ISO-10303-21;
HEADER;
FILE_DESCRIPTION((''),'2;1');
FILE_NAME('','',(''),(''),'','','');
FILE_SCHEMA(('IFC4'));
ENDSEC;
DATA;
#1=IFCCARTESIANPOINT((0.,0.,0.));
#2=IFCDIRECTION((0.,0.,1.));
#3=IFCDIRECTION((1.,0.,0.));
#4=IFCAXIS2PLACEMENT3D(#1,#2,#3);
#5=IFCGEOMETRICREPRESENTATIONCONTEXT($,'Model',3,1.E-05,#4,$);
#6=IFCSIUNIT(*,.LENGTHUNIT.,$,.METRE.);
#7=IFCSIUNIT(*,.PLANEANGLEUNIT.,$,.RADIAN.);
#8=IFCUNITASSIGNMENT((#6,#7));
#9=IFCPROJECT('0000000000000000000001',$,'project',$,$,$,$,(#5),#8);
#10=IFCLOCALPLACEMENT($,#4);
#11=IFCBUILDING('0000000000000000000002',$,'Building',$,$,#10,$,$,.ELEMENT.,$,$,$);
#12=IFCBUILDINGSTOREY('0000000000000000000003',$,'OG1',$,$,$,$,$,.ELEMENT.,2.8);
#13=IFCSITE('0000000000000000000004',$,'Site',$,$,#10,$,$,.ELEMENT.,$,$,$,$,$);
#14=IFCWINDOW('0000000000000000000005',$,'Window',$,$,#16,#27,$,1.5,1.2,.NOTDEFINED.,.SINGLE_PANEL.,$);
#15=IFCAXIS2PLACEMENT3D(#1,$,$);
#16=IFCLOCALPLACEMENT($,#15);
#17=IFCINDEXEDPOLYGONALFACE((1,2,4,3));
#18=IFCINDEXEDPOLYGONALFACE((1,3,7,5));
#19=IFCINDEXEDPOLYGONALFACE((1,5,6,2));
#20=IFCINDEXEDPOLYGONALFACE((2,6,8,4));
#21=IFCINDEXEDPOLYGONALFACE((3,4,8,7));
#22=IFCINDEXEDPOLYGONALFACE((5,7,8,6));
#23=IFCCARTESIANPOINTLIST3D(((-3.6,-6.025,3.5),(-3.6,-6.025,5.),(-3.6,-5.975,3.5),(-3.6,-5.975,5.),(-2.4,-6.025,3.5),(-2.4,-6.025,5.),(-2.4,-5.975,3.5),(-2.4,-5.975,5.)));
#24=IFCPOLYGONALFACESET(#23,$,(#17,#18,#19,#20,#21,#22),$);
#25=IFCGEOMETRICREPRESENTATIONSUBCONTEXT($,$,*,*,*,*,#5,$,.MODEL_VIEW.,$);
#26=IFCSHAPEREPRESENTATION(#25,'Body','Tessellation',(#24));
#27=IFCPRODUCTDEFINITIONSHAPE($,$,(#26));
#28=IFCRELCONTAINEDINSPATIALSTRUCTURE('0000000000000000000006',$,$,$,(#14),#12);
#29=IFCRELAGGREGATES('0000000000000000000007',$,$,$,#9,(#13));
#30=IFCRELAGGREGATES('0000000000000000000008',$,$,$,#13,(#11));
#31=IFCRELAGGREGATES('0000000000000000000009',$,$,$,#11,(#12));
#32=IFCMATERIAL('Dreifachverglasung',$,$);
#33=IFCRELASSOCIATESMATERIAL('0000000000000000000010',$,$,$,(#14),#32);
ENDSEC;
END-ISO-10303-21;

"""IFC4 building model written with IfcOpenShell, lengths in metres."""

from ifc_helpers import new_model, si_unit, frame, origin, origin_with_axes, origin_2d, place, context, subcontext, project, spatial, rectangle, extrude, material, element, save


model = new_model("IFC4")

# Units and contexts
model_context = context("Model", 3, precision=1e-05, world=origin_with_axes())
sub_context = subcontext(model_context, None, None, "MODEL_VIEW")
ifc_project = project(units=[si_unit("LENGTHUNIT", "METRE"), si_unit("PLANEANGLEUNIT", "RADIAN")], contexts=[model_context])

# Site, building, storey
placement_1 = place(None, origin_with_axes())
site = spatial("IfcSite", under=ifc_project, at=placement_1, Name="Site", CompositionType="ELEMENT")
building = spatial("IfcBuilding", under=site, at=placement_1, Name="Building", CompositionType="ELEMENT")
storey = spatial("IfcBuildingStorey", under=building, Name="OG1", CompositionType="ELEMENT", Elevation=2.8)

# Window
ifc_material = material(Name="Dreifachverglasung")
placement_2 = place(None, origin_with_axes())
window_placement = place(placement_2, frame((-3.0, -6.0, 3.5)))
element("IfcWindow", 1, at=window_placement, inside=storey, material=ifc_material, Name="Window", OverallHeight=1.5, OverallWidth=1.2, PartitioningType="SINGLE_PANEL", PredefinedType="NOTDEFINED", context=sub_context, shape_type="SweptSolid", body=[
    extrude(rectangle(XDim=1.2, YDim=0.05, at=origin_2d()), origin(), (0.0, 0.0, 1.0), 1.5),
])

save(model, "model.ifc")
